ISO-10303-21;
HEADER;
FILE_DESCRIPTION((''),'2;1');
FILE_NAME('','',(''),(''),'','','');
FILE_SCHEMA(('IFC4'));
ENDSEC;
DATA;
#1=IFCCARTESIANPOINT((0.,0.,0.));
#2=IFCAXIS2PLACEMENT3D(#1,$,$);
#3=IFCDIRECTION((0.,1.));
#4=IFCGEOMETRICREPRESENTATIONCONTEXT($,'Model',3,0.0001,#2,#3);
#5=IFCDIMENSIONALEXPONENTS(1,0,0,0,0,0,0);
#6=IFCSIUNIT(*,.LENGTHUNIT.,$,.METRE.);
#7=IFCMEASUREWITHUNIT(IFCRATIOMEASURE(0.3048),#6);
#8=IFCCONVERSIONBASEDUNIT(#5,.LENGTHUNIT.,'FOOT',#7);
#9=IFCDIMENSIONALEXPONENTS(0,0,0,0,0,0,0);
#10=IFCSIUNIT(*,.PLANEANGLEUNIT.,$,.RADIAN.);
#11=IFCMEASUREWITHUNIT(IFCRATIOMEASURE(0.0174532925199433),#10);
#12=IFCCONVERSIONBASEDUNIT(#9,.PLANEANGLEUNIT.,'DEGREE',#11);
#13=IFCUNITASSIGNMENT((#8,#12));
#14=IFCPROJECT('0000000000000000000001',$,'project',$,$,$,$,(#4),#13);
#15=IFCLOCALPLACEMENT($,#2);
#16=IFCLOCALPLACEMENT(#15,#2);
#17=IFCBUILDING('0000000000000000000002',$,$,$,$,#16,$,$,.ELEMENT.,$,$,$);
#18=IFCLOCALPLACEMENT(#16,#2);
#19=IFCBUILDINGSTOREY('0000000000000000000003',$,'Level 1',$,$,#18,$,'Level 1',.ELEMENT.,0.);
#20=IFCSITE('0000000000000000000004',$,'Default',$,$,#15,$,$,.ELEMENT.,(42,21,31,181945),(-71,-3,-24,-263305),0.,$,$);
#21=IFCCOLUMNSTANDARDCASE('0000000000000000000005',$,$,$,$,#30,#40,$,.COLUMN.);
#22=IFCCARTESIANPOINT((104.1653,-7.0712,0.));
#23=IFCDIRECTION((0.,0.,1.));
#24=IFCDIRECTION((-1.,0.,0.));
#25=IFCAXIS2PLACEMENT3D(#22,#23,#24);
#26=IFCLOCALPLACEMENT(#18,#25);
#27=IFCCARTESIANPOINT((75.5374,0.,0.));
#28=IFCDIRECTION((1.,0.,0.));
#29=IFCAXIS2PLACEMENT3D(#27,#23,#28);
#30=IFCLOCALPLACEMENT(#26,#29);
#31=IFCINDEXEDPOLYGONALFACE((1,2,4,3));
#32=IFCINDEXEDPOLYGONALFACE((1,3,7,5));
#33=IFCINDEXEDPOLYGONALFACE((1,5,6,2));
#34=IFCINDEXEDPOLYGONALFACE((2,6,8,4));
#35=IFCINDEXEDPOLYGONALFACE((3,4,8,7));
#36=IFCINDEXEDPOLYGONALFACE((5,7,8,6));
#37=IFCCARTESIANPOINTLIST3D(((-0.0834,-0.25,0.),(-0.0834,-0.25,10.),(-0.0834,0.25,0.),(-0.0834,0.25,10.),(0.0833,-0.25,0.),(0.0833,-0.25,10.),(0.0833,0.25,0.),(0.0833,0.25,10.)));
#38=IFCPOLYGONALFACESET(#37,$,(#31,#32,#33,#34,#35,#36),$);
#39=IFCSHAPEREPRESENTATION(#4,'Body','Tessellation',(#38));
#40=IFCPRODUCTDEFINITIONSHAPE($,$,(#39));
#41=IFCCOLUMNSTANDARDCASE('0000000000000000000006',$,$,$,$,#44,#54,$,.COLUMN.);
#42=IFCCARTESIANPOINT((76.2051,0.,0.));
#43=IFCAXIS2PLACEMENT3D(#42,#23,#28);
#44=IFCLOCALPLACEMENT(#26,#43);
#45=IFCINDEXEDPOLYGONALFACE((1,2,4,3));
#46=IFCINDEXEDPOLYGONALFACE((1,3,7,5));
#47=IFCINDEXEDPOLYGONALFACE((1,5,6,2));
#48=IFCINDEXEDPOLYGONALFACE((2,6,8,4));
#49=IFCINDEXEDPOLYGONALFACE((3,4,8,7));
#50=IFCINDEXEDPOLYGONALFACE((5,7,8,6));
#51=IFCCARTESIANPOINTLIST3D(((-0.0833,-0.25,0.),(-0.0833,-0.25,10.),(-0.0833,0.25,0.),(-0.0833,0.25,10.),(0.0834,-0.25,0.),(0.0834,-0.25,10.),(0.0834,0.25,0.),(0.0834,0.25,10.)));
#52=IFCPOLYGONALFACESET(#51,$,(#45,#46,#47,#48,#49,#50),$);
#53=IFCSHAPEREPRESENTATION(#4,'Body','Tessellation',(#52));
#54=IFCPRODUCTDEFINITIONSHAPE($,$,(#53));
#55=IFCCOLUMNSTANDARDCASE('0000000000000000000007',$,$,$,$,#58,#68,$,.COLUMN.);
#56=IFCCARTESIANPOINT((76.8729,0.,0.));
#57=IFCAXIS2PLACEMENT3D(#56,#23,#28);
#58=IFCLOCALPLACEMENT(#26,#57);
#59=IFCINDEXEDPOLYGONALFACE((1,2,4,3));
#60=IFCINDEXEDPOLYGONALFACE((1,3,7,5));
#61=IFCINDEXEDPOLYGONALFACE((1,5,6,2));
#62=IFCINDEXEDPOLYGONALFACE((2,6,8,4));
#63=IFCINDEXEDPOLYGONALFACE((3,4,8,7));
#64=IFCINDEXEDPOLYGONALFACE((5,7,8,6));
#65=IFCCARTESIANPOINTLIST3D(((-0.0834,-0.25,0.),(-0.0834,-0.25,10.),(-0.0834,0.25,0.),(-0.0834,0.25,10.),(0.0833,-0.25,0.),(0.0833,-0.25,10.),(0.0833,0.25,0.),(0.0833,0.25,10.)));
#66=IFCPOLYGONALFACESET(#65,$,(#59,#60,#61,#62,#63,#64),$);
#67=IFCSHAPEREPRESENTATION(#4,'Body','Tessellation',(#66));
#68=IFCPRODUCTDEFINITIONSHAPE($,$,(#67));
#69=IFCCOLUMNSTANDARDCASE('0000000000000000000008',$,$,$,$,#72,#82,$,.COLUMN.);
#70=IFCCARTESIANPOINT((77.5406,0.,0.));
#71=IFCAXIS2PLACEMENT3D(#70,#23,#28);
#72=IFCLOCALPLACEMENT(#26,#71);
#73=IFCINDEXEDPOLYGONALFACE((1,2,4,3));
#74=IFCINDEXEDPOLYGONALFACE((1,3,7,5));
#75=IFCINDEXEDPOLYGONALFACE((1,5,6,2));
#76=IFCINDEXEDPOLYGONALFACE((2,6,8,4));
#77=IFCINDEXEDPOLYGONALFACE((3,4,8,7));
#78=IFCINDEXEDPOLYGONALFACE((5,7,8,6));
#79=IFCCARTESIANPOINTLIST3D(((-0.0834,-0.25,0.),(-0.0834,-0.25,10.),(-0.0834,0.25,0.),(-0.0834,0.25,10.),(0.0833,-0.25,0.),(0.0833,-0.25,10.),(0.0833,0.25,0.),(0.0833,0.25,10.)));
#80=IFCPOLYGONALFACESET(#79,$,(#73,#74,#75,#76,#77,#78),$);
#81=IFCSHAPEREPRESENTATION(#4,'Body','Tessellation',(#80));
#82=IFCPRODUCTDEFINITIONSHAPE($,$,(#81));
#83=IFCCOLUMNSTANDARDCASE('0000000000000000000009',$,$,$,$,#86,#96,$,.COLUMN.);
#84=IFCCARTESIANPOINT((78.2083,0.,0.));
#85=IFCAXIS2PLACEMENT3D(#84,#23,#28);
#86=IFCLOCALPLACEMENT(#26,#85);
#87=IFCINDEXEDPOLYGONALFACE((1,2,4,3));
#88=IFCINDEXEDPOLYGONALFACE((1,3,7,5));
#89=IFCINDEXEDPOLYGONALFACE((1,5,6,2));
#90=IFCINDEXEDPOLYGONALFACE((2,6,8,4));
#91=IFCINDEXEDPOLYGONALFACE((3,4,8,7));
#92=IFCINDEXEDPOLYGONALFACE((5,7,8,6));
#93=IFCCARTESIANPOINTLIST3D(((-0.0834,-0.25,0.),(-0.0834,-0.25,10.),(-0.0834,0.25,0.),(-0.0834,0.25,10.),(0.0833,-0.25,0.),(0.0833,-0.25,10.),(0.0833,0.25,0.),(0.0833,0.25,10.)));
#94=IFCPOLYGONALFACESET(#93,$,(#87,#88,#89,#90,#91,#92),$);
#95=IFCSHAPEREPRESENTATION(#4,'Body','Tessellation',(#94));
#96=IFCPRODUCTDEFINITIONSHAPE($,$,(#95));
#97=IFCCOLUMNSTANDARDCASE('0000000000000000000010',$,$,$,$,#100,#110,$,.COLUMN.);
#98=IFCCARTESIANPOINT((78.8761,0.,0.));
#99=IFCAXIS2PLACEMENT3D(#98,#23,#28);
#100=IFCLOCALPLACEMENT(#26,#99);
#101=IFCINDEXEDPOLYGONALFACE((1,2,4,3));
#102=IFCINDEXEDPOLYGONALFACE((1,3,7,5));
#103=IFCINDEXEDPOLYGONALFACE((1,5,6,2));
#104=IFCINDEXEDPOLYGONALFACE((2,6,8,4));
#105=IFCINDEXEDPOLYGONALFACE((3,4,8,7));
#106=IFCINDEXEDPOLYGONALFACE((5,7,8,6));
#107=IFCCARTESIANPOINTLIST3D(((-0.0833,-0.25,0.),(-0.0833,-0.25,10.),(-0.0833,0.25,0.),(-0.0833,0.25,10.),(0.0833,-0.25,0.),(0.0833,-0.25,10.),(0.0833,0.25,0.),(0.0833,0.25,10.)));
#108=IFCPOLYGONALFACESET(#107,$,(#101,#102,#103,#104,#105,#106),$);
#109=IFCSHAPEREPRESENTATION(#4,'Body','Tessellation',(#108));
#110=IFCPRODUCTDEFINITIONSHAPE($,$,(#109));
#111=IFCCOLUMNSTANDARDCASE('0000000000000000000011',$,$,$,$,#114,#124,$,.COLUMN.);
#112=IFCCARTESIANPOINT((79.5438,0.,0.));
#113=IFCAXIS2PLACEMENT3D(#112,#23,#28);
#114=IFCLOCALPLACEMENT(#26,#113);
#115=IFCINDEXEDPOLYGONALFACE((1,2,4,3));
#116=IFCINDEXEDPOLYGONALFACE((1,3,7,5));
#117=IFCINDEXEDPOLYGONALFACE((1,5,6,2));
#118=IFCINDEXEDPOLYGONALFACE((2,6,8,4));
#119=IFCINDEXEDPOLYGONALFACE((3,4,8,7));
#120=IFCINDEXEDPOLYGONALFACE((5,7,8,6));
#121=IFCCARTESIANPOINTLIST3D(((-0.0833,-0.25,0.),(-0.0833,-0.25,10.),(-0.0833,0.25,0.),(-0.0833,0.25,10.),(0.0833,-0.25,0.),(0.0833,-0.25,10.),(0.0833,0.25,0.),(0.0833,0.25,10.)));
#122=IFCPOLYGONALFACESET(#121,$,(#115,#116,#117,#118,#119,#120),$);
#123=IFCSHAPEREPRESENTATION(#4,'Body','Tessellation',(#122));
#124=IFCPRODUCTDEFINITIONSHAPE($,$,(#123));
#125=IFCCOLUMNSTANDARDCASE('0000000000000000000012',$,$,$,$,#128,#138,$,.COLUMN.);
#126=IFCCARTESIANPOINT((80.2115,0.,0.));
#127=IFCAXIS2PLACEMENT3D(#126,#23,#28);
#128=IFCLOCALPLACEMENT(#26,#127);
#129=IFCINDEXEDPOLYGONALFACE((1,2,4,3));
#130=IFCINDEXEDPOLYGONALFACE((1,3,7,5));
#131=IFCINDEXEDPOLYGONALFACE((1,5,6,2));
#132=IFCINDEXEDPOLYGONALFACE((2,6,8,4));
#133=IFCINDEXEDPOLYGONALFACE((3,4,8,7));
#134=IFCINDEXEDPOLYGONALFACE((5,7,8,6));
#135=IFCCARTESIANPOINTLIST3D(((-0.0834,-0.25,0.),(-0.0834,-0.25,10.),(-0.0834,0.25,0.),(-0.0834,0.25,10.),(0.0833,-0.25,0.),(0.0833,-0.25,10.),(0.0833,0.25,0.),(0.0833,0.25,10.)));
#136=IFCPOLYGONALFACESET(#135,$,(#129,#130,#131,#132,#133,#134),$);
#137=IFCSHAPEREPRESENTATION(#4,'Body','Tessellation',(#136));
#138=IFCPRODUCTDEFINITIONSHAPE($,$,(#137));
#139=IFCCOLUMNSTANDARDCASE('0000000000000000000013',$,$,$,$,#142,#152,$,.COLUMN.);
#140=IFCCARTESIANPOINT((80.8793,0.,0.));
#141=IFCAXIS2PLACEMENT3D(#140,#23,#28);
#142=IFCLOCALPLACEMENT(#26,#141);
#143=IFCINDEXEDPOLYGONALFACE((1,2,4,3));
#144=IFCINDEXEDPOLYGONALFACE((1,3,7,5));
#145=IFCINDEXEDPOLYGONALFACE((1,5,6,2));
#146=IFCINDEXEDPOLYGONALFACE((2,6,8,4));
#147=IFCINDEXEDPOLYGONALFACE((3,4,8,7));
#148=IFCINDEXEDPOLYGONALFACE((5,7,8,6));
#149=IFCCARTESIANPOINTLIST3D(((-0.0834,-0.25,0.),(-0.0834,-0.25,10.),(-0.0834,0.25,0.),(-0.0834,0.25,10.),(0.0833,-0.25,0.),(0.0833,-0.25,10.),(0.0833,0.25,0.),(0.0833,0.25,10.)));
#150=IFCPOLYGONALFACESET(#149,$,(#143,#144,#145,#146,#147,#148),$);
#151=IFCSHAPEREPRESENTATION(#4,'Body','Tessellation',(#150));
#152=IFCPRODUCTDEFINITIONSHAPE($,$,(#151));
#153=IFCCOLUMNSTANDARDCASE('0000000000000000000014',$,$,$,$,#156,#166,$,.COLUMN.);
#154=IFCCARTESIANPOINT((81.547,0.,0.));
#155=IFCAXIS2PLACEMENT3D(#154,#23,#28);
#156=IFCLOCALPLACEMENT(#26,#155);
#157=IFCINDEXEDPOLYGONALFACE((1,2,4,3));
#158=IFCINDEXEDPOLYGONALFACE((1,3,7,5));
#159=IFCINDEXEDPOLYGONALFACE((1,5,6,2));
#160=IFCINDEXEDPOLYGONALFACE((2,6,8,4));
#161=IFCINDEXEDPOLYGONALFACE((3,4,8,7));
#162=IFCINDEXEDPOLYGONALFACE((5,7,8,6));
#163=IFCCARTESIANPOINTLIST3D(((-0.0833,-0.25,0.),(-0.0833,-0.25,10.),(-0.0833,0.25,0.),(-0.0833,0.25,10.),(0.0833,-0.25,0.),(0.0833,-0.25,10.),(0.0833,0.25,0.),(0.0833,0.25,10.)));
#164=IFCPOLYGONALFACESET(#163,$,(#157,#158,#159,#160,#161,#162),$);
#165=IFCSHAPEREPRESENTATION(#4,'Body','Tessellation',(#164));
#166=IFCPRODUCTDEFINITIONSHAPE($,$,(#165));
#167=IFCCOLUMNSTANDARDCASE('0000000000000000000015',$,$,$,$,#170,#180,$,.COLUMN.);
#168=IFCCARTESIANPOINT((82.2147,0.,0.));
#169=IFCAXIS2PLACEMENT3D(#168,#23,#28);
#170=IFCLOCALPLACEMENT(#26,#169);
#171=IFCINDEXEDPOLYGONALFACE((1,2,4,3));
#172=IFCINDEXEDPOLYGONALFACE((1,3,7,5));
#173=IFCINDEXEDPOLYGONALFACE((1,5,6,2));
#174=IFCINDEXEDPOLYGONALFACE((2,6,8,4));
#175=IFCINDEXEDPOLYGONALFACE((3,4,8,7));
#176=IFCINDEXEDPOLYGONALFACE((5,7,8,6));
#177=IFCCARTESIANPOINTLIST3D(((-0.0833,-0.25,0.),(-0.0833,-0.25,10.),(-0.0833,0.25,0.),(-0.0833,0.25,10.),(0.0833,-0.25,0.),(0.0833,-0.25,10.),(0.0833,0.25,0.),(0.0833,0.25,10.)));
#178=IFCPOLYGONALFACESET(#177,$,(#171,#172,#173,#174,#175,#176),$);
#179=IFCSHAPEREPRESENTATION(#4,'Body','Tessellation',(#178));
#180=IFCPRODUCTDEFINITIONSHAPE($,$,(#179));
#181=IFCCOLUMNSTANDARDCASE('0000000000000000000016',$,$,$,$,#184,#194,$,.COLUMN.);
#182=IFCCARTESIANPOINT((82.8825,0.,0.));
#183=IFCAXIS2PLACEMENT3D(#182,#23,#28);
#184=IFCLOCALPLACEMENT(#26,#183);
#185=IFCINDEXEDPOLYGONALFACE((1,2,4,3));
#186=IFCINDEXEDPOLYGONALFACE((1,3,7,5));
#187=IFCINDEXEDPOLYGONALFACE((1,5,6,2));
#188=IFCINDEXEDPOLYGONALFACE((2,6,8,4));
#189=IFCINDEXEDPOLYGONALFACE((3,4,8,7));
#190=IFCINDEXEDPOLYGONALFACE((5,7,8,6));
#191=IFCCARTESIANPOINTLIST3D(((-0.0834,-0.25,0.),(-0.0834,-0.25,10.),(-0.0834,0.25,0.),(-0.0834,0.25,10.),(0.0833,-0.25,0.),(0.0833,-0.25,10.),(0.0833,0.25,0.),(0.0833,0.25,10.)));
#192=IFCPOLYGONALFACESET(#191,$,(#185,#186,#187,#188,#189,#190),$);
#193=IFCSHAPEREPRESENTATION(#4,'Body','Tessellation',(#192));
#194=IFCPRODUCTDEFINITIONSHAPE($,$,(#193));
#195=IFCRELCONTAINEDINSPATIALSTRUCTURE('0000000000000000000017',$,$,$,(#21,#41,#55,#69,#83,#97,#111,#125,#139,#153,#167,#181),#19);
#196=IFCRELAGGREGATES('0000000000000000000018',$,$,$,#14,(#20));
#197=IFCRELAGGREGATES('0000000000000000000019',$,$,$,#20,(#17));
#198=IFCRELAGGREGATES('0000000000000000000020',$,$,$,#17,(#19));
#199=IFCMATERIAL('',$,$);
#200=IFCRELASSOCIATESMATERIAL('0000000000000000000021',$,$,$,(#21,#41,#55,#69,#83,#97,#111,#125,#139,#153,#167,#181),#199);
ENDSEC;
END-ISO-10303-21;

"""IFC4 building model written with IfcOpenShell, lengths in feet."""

from ifc_helpers import new_model, entity, si_unit, converted_unit, direction, frame, origin, place, context, project, spatial, rectangle, extrude, material, element, save


model = new_model("IFC4")

# Units and contexts
model_context = context("Model", 3, precision=0.0001, world=origin(), true_north=direction((0.0, 1.0)))
ifc_project = project(units=[converted_unit("LENGTHUNIT", "FOOT", entity("IfcRatioMeasure", 0.3048), si_unit("LENGTHUNIT", "METRE"), dimensions=[1, 0, 0, 0, 0, 0, 0]), converted_unit("PLANEANGLEUNIT", "DEGREE", entity("IfcRatioMeasure", 0.0174532925199433), si_unit("PLANEANGLEUNIT", "RADIAN"), dimensions=[0, 0, 0, 0, 0, 0, 0])], contexts=[model_context])

# Site, building, storey
site_placement = place(None, origin())
site = spatial("IfcSite", under=ifc_project, at=site_placement, Name="Default", CompositionType="ELEMENT", RefLatitude=(42, 21, 31, 181945), RefLongitude=(-71, -3, -24, -263305), RefElevation=0.0)
building_placement = place(site_placement, origin())
building = spatial("IfcBuilding", under=site, at=building_placement, CompositionType="ELEMENT")
storey_placement = place(building_placement, origin())
storey = spatial("IfcBuildingStorey", under=building, at=storey_placement, Name="Level 1", LongName="Level 1", CompositionType="ELEMENT", Elevation=0.0)

# Columns
ifc_material = material(Name="")
placement = place(storey_placement, frame((104.1653, -7.0712, 0.0), z_axis=(0.0, 0.0, 1.0), x_axis=(-1.0, 0.0, 0.0)))
for number, where, z_axis, x_axis in (
    (1, (75.5374, 0.0, 0.0), (0.0, 0.0, 1.0), (1.0, 0.0, 0.0)),
    (2, (76.2051, 0.0, 0.0), (0.0, 0.0, 1.0), (1.0, 0.0, 0.0)),
    (3, (76.8729, 0.0, 0.0), (0.0, 0.0, 1.0), (1.0, 0.0, 0.0)),
    (4, (77.5406, 0.0, 0.0), (0.0, 0.0, 1.0), (1.0, 0.0, 0.0)),
    (5, (78.2083, 0.0, 0.0), (0.0, 0.0, 1.0), (1.0, 0.0, 0.0)),
    (6, (78.8761, 0.0, 0.0), (0.0, 0.0, 1.0), (1.0, 0.0, 0.0)),
    (7, (79.5438, 0.0, 0.0), (0.0, 0.0, 1.0), (1.0, 0.0, 0.0)),
    (8, (80.2115, 0.0, 0.0), (0.0, 0.0, 1.0), (1.0, 0.0, 0.0)),
    (9, (80.8793, 0.0, 0.0), (0.0, 0.0, 1.0), (1.0, 0.0, 0.0)),
    (10, (81.547, 0.0, 0.0), (0.0, 0.0, 1.0), (1.0, 0.0, 0.0)),
    (11, (82.2147, 0.0, 0.0), (0.0, 0.0, 1.0), (1.0, 0.0, 0.0)),
    (12, (82.8825, 0.0, 0.0), (0.0, 0.0, 1.0), (1.0, 0.0, 0.0)),
):
    element("IfcColumnStandardCase", number, at=place(placement, frame(where, z_axis=z_axis, x_axis=x_axis)), inside=storey, material=ifc_material, PredefinedType="COLUMN", context=model_context, shape_type="SweptSolid", body=[
        extrude(rectangle(XDim=0.1667, YDim=0.5), origin(), (0.0, 0.0, 1.0), 10.0),
    ])

save(model, "model.ifc")
